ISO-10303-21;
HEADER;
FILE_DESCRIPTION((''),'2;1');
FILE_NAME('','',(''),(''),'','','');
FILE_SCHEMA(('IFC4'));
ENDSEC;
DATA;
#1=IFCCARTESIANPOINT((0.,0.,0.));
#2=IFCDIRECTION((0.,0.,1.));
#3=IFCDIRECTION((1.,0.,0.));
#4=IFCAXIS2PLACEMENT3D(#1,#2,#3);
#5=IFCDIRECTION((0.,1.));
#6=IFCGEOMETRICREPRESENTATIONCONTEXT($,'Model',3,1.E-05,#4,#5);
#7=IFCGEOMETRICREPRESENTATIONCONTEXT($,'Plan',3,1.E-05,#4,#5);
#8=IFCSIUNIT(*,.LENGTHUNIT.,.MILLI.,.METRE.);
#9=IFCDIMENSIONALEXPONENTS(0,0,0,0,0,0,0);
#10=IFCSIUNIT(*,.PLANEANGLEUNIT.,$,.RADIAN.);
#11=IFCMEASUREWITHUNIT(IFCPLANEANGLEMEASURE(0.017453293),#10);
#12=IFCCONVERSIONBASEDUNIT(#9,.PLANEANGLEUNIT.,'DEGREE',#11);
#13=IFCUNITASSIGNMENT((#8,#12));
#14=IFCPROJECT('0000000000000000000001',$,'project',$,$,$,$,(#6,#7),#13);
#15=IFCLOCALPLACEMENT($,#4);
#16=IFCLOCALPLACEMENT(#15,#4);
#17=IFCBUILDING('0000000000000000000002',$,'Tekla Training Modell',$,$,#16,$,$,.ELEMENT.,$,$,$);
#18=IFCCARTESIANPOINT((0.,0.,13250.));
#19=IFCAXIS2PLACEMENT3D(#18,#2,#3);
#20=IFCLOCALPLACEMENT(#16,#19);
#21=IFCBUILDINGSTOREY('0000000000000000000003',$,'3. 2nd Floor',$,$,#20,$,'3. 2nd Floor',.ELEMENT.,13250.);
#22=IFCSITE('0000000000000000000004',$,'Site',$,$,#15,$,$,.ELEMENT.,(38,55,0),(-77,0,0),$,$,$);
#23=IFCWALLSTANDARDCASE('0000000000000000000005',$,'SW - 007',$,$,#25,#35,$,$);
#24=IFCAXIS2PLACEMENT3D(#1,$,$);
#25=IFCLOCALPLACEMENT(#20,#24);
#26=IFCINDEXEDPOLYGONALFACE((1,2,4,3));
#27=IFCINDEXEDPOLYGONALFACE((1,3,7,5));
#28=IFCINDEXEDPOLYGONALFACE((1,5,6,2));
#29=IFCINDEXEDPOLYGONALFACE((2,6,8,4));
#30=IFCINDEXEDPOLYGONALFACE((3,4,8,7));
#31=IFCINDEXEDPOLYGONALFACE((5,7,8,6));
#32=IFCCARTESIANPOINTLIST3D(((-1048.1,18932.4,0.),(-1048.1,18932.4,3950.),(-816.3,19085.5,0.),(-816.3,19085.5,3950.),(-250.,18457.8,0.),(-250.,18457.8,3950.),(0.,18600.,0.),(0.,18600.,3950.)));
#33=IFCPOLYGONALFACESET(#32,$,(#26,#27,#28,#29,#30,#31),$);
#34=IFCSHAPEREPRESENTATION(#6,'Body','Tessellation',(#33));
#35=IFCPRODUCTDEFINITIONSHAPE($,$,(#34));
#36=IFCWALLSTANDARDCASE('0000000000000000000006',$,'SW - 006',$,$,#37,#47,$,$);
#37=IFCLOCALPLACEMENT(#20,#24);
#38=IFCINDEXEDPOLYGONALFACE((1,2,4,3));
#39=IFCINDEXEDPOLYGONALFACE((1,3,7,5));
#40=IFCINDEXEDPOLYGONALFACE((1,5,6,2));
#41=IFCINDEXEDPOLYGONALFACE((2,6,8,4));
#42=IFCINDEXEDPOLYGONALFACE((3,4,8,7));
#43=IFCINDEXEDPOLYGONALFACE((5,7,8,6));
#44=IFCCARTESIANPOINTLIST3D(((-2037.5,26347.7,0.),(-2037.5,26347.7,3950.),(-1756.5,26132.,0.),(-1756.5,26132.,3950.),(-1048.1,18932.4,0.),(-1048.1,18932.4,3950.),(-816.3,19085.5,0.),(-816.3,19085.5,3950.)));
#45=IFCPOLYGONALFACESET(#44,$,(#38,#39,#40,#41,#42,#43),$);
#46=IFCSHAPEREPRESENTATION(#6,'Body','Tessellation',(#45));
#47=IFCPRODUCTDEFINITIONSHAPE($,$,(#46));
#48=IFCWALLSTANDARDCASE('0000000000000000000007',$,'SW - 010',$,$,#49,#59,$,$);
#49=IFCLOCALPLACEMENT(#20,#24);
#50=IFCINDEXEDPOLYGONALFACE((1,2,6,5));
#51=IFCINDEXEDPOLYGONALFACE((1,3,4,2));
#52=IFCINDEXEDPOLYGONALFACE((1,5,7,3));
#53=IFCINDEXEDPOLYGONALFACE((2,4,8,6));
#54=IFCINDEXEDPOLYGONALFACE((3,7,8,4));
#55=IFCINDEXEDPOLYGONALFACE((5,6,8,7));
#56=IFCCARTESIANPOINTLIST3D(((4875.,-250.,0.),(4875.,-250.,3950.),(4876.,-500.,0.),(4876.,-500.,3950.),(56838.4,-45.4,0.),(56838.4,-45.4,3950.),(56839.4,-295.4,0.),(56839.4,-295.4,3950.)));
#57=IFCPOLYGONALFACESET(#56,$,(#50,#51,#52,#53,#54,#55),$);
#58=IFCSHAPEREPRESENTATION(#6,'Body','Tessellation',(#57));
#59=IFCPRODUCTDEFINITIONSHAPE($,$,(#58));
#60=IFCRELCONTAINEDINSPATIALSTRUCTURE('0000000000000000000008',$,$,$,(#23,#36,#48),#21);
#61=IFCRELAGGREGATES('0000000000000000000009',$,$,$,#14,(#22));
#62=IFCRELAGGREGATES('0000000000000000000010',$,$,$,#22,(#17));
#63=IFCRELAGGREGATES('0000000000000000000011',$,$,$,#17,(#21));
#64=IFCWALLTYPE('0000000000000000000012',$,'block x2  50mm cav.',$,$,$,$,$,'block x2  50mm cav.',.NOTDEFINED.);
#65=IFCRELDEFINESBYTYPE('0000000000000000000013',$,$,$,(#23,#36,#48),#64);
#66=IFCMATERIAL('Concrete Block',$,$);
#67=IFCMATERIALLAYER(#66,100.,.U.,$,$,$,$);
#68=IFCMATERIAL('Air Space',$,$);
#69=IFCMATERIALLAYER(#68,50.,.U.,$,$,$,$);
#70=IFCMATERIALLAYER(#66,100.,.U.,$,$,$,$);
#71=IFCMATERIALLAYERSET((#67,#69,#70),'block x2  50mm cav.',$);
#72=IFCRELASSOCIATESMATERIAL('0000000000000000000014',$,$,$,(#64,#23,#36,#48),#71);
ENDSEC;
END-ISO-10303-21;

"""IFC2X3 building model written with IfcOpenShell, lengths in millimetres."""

from ifc_helpers import new_model, entity, si_unit, converted_unit, direction, frame, origin_with_axes, place, context, project, spatial, polyline, outline, extrude, material, layer, layer_set, layer_usage, type_object, element, save


model = new_model("IFC2X3")

# Units and contexts
model_context = context("Model", 3, precision=1e-05, world=origin_with_axes(), true_north=direction((0.0, 1.0)))
plan_context = context("Plan", 3, precision=1e-05, world=origin_with_axes(), true_north=direction((0.0, 1.0)))
ifc_project = project(units=[si_unit("LENGTHUNIT", "METRE", prefix="MILLI"), converted_unit("PLANEANGLEUNIT", "DEGREE", entity("IfcPlaneAngleMeasure", 0.017453293), si_unit("PLANEANGLEUNIT", "RADIAN"), dimensions=[0, 0, 0, 0, 0, 0, 0])], contexts=[model_context, plan_context])

# Site, building, storey
site_placement = place(None, origin_with_axes())
site = spatial("IfcSite", under=ifc_project, at=site_placement, Name="Site", CompositionType="ELEMENT", RefLatitude=(38, 55, 0), RefLongitude=(-77, 0, 0))
building_placement = place(site_placement, origin_with_axes())
building = spatial("IfcBuilding", under=site, at=building_placement, Name="Tekla Training Modell", CompositionType="ELEMENT")
storey_placement = place(building_placement, frame((0.0, 0.0, 13250.0), z_axis=(0.0, 0.0, 1.0), x_axis=(1.0, 0.0, 0.0)))
storey = spatial("IfcBuildingStorey", under=building, at=storey_placement, Name="3. 2nd Floor", LongName="3. 2nd Floor", CompositionType="ELEMENT", Elevation=13250.0)

# Walls
ifc_material_1 = material(Name="Concrete Block")
ifc_layer_1 = layer(ifc_material_1, 100.0, ventilated="UNKNOWN")
ifc_material_2 = material(Name="Air Space")
ifc_layer_2 = layer(ifc_material_2, 50.0, ventilated="UNKNOWN")
ifc_layer_3 = layer(ifc_material_1, 100.0, ventilated="UNKNOWN")
ifc_layer_set_1 = layer_set([ifc_layer_1, ifc_layer_2, ifc_layer_3], Name="block x2  50mm cav.")
wall_type = type_object("IfcWallType", Name="block x2  50mm cav.", ElementType="block x2  50mm cav.", PredefinedType="NOTDEFINED", material=ifc_layer_set_1)
ifc_layer_usage_1 = layer_usage(ifc_layer_set_1, "AXIS2", "NEGATIVE", 0.0)
wall_1_placement = place(storey_placement, frame((-816.3, 19085.5, 0.0), z_axis=(0.0, 0.0, 1.0), x_axis=(0.859493, -0.511147, 0.0)))
element("IfcWallStandardCase", 1, at=wall_1_placement, inside=storey, type_object=wall_type, material=ifc_layer_usage_1, Name="SW - 007", context=model_context, shape_type="SweptSolid", body=[
    extrude(outline(polyline([(-121.0, -250.0), (807.6, -250.0), (949.7, 0.0), (0.0, 0.0), (-121.0, -250.0)])), origin_with_axes(), (0.0, 0.0, 1.0), 3950.0),
])
ifc_layer_usage_2 = layer_usage(ifc_layer_set_1, "AXIS2", "NEGATIVE", 0.0)
wall_2_placement = place(storey_placement, frame((-1756.5, 26132.0, 0.0), z_axis=(0.0, 0.0, 1.0), x_axis=(0.132257, -0.991215, 0.0)))
element("IfcWallStandardCase", 2, at=wall_2_placement, inside=storey, type_object=wall_type, material=ifc_layer_usage_2, Name="SW - 006", context=model_context, shape_type="SweptSolid", body=[
    extrude(outline(polyline([(-251.0, -250.0), (7230.0, -250.0), (7109.0, 0.0), (0.0, 0.0), (-251.0, -250.0)])), origin_with_axes(), (0.0, 0.0, 1.0), 3950.0),
])
ifc_layer_usage_3 = layer_usage(ifc_layer_set_1, "AXIS2", "NEGATIVE", 0.0)
wall_3_placement = place(storey_placement, frame((4875.0, -250.0, 0.0), z_axis=(0.0, 0.0, 1.0), x_axis=(0.999992, 0.003937, 0.0)))
element("IfcWallStandardCase", 3, at=wall_3_placement, inside=storey, type_object=wall_type, material=ifc_layer_usage_3, Name="SW - 010", context=model_context, shape_type="SweptSolid", body=[
    extrude(outline(polyline([(0.0, -250.0), (51963.8, -250.0), (51963.8, 0.0), (0.0, 0.0), (0.0, -250.0)])), origin_with_axes(), (0.0, 0.0, 1.0), 3950.0),
])

save(model, "model.ifc")
